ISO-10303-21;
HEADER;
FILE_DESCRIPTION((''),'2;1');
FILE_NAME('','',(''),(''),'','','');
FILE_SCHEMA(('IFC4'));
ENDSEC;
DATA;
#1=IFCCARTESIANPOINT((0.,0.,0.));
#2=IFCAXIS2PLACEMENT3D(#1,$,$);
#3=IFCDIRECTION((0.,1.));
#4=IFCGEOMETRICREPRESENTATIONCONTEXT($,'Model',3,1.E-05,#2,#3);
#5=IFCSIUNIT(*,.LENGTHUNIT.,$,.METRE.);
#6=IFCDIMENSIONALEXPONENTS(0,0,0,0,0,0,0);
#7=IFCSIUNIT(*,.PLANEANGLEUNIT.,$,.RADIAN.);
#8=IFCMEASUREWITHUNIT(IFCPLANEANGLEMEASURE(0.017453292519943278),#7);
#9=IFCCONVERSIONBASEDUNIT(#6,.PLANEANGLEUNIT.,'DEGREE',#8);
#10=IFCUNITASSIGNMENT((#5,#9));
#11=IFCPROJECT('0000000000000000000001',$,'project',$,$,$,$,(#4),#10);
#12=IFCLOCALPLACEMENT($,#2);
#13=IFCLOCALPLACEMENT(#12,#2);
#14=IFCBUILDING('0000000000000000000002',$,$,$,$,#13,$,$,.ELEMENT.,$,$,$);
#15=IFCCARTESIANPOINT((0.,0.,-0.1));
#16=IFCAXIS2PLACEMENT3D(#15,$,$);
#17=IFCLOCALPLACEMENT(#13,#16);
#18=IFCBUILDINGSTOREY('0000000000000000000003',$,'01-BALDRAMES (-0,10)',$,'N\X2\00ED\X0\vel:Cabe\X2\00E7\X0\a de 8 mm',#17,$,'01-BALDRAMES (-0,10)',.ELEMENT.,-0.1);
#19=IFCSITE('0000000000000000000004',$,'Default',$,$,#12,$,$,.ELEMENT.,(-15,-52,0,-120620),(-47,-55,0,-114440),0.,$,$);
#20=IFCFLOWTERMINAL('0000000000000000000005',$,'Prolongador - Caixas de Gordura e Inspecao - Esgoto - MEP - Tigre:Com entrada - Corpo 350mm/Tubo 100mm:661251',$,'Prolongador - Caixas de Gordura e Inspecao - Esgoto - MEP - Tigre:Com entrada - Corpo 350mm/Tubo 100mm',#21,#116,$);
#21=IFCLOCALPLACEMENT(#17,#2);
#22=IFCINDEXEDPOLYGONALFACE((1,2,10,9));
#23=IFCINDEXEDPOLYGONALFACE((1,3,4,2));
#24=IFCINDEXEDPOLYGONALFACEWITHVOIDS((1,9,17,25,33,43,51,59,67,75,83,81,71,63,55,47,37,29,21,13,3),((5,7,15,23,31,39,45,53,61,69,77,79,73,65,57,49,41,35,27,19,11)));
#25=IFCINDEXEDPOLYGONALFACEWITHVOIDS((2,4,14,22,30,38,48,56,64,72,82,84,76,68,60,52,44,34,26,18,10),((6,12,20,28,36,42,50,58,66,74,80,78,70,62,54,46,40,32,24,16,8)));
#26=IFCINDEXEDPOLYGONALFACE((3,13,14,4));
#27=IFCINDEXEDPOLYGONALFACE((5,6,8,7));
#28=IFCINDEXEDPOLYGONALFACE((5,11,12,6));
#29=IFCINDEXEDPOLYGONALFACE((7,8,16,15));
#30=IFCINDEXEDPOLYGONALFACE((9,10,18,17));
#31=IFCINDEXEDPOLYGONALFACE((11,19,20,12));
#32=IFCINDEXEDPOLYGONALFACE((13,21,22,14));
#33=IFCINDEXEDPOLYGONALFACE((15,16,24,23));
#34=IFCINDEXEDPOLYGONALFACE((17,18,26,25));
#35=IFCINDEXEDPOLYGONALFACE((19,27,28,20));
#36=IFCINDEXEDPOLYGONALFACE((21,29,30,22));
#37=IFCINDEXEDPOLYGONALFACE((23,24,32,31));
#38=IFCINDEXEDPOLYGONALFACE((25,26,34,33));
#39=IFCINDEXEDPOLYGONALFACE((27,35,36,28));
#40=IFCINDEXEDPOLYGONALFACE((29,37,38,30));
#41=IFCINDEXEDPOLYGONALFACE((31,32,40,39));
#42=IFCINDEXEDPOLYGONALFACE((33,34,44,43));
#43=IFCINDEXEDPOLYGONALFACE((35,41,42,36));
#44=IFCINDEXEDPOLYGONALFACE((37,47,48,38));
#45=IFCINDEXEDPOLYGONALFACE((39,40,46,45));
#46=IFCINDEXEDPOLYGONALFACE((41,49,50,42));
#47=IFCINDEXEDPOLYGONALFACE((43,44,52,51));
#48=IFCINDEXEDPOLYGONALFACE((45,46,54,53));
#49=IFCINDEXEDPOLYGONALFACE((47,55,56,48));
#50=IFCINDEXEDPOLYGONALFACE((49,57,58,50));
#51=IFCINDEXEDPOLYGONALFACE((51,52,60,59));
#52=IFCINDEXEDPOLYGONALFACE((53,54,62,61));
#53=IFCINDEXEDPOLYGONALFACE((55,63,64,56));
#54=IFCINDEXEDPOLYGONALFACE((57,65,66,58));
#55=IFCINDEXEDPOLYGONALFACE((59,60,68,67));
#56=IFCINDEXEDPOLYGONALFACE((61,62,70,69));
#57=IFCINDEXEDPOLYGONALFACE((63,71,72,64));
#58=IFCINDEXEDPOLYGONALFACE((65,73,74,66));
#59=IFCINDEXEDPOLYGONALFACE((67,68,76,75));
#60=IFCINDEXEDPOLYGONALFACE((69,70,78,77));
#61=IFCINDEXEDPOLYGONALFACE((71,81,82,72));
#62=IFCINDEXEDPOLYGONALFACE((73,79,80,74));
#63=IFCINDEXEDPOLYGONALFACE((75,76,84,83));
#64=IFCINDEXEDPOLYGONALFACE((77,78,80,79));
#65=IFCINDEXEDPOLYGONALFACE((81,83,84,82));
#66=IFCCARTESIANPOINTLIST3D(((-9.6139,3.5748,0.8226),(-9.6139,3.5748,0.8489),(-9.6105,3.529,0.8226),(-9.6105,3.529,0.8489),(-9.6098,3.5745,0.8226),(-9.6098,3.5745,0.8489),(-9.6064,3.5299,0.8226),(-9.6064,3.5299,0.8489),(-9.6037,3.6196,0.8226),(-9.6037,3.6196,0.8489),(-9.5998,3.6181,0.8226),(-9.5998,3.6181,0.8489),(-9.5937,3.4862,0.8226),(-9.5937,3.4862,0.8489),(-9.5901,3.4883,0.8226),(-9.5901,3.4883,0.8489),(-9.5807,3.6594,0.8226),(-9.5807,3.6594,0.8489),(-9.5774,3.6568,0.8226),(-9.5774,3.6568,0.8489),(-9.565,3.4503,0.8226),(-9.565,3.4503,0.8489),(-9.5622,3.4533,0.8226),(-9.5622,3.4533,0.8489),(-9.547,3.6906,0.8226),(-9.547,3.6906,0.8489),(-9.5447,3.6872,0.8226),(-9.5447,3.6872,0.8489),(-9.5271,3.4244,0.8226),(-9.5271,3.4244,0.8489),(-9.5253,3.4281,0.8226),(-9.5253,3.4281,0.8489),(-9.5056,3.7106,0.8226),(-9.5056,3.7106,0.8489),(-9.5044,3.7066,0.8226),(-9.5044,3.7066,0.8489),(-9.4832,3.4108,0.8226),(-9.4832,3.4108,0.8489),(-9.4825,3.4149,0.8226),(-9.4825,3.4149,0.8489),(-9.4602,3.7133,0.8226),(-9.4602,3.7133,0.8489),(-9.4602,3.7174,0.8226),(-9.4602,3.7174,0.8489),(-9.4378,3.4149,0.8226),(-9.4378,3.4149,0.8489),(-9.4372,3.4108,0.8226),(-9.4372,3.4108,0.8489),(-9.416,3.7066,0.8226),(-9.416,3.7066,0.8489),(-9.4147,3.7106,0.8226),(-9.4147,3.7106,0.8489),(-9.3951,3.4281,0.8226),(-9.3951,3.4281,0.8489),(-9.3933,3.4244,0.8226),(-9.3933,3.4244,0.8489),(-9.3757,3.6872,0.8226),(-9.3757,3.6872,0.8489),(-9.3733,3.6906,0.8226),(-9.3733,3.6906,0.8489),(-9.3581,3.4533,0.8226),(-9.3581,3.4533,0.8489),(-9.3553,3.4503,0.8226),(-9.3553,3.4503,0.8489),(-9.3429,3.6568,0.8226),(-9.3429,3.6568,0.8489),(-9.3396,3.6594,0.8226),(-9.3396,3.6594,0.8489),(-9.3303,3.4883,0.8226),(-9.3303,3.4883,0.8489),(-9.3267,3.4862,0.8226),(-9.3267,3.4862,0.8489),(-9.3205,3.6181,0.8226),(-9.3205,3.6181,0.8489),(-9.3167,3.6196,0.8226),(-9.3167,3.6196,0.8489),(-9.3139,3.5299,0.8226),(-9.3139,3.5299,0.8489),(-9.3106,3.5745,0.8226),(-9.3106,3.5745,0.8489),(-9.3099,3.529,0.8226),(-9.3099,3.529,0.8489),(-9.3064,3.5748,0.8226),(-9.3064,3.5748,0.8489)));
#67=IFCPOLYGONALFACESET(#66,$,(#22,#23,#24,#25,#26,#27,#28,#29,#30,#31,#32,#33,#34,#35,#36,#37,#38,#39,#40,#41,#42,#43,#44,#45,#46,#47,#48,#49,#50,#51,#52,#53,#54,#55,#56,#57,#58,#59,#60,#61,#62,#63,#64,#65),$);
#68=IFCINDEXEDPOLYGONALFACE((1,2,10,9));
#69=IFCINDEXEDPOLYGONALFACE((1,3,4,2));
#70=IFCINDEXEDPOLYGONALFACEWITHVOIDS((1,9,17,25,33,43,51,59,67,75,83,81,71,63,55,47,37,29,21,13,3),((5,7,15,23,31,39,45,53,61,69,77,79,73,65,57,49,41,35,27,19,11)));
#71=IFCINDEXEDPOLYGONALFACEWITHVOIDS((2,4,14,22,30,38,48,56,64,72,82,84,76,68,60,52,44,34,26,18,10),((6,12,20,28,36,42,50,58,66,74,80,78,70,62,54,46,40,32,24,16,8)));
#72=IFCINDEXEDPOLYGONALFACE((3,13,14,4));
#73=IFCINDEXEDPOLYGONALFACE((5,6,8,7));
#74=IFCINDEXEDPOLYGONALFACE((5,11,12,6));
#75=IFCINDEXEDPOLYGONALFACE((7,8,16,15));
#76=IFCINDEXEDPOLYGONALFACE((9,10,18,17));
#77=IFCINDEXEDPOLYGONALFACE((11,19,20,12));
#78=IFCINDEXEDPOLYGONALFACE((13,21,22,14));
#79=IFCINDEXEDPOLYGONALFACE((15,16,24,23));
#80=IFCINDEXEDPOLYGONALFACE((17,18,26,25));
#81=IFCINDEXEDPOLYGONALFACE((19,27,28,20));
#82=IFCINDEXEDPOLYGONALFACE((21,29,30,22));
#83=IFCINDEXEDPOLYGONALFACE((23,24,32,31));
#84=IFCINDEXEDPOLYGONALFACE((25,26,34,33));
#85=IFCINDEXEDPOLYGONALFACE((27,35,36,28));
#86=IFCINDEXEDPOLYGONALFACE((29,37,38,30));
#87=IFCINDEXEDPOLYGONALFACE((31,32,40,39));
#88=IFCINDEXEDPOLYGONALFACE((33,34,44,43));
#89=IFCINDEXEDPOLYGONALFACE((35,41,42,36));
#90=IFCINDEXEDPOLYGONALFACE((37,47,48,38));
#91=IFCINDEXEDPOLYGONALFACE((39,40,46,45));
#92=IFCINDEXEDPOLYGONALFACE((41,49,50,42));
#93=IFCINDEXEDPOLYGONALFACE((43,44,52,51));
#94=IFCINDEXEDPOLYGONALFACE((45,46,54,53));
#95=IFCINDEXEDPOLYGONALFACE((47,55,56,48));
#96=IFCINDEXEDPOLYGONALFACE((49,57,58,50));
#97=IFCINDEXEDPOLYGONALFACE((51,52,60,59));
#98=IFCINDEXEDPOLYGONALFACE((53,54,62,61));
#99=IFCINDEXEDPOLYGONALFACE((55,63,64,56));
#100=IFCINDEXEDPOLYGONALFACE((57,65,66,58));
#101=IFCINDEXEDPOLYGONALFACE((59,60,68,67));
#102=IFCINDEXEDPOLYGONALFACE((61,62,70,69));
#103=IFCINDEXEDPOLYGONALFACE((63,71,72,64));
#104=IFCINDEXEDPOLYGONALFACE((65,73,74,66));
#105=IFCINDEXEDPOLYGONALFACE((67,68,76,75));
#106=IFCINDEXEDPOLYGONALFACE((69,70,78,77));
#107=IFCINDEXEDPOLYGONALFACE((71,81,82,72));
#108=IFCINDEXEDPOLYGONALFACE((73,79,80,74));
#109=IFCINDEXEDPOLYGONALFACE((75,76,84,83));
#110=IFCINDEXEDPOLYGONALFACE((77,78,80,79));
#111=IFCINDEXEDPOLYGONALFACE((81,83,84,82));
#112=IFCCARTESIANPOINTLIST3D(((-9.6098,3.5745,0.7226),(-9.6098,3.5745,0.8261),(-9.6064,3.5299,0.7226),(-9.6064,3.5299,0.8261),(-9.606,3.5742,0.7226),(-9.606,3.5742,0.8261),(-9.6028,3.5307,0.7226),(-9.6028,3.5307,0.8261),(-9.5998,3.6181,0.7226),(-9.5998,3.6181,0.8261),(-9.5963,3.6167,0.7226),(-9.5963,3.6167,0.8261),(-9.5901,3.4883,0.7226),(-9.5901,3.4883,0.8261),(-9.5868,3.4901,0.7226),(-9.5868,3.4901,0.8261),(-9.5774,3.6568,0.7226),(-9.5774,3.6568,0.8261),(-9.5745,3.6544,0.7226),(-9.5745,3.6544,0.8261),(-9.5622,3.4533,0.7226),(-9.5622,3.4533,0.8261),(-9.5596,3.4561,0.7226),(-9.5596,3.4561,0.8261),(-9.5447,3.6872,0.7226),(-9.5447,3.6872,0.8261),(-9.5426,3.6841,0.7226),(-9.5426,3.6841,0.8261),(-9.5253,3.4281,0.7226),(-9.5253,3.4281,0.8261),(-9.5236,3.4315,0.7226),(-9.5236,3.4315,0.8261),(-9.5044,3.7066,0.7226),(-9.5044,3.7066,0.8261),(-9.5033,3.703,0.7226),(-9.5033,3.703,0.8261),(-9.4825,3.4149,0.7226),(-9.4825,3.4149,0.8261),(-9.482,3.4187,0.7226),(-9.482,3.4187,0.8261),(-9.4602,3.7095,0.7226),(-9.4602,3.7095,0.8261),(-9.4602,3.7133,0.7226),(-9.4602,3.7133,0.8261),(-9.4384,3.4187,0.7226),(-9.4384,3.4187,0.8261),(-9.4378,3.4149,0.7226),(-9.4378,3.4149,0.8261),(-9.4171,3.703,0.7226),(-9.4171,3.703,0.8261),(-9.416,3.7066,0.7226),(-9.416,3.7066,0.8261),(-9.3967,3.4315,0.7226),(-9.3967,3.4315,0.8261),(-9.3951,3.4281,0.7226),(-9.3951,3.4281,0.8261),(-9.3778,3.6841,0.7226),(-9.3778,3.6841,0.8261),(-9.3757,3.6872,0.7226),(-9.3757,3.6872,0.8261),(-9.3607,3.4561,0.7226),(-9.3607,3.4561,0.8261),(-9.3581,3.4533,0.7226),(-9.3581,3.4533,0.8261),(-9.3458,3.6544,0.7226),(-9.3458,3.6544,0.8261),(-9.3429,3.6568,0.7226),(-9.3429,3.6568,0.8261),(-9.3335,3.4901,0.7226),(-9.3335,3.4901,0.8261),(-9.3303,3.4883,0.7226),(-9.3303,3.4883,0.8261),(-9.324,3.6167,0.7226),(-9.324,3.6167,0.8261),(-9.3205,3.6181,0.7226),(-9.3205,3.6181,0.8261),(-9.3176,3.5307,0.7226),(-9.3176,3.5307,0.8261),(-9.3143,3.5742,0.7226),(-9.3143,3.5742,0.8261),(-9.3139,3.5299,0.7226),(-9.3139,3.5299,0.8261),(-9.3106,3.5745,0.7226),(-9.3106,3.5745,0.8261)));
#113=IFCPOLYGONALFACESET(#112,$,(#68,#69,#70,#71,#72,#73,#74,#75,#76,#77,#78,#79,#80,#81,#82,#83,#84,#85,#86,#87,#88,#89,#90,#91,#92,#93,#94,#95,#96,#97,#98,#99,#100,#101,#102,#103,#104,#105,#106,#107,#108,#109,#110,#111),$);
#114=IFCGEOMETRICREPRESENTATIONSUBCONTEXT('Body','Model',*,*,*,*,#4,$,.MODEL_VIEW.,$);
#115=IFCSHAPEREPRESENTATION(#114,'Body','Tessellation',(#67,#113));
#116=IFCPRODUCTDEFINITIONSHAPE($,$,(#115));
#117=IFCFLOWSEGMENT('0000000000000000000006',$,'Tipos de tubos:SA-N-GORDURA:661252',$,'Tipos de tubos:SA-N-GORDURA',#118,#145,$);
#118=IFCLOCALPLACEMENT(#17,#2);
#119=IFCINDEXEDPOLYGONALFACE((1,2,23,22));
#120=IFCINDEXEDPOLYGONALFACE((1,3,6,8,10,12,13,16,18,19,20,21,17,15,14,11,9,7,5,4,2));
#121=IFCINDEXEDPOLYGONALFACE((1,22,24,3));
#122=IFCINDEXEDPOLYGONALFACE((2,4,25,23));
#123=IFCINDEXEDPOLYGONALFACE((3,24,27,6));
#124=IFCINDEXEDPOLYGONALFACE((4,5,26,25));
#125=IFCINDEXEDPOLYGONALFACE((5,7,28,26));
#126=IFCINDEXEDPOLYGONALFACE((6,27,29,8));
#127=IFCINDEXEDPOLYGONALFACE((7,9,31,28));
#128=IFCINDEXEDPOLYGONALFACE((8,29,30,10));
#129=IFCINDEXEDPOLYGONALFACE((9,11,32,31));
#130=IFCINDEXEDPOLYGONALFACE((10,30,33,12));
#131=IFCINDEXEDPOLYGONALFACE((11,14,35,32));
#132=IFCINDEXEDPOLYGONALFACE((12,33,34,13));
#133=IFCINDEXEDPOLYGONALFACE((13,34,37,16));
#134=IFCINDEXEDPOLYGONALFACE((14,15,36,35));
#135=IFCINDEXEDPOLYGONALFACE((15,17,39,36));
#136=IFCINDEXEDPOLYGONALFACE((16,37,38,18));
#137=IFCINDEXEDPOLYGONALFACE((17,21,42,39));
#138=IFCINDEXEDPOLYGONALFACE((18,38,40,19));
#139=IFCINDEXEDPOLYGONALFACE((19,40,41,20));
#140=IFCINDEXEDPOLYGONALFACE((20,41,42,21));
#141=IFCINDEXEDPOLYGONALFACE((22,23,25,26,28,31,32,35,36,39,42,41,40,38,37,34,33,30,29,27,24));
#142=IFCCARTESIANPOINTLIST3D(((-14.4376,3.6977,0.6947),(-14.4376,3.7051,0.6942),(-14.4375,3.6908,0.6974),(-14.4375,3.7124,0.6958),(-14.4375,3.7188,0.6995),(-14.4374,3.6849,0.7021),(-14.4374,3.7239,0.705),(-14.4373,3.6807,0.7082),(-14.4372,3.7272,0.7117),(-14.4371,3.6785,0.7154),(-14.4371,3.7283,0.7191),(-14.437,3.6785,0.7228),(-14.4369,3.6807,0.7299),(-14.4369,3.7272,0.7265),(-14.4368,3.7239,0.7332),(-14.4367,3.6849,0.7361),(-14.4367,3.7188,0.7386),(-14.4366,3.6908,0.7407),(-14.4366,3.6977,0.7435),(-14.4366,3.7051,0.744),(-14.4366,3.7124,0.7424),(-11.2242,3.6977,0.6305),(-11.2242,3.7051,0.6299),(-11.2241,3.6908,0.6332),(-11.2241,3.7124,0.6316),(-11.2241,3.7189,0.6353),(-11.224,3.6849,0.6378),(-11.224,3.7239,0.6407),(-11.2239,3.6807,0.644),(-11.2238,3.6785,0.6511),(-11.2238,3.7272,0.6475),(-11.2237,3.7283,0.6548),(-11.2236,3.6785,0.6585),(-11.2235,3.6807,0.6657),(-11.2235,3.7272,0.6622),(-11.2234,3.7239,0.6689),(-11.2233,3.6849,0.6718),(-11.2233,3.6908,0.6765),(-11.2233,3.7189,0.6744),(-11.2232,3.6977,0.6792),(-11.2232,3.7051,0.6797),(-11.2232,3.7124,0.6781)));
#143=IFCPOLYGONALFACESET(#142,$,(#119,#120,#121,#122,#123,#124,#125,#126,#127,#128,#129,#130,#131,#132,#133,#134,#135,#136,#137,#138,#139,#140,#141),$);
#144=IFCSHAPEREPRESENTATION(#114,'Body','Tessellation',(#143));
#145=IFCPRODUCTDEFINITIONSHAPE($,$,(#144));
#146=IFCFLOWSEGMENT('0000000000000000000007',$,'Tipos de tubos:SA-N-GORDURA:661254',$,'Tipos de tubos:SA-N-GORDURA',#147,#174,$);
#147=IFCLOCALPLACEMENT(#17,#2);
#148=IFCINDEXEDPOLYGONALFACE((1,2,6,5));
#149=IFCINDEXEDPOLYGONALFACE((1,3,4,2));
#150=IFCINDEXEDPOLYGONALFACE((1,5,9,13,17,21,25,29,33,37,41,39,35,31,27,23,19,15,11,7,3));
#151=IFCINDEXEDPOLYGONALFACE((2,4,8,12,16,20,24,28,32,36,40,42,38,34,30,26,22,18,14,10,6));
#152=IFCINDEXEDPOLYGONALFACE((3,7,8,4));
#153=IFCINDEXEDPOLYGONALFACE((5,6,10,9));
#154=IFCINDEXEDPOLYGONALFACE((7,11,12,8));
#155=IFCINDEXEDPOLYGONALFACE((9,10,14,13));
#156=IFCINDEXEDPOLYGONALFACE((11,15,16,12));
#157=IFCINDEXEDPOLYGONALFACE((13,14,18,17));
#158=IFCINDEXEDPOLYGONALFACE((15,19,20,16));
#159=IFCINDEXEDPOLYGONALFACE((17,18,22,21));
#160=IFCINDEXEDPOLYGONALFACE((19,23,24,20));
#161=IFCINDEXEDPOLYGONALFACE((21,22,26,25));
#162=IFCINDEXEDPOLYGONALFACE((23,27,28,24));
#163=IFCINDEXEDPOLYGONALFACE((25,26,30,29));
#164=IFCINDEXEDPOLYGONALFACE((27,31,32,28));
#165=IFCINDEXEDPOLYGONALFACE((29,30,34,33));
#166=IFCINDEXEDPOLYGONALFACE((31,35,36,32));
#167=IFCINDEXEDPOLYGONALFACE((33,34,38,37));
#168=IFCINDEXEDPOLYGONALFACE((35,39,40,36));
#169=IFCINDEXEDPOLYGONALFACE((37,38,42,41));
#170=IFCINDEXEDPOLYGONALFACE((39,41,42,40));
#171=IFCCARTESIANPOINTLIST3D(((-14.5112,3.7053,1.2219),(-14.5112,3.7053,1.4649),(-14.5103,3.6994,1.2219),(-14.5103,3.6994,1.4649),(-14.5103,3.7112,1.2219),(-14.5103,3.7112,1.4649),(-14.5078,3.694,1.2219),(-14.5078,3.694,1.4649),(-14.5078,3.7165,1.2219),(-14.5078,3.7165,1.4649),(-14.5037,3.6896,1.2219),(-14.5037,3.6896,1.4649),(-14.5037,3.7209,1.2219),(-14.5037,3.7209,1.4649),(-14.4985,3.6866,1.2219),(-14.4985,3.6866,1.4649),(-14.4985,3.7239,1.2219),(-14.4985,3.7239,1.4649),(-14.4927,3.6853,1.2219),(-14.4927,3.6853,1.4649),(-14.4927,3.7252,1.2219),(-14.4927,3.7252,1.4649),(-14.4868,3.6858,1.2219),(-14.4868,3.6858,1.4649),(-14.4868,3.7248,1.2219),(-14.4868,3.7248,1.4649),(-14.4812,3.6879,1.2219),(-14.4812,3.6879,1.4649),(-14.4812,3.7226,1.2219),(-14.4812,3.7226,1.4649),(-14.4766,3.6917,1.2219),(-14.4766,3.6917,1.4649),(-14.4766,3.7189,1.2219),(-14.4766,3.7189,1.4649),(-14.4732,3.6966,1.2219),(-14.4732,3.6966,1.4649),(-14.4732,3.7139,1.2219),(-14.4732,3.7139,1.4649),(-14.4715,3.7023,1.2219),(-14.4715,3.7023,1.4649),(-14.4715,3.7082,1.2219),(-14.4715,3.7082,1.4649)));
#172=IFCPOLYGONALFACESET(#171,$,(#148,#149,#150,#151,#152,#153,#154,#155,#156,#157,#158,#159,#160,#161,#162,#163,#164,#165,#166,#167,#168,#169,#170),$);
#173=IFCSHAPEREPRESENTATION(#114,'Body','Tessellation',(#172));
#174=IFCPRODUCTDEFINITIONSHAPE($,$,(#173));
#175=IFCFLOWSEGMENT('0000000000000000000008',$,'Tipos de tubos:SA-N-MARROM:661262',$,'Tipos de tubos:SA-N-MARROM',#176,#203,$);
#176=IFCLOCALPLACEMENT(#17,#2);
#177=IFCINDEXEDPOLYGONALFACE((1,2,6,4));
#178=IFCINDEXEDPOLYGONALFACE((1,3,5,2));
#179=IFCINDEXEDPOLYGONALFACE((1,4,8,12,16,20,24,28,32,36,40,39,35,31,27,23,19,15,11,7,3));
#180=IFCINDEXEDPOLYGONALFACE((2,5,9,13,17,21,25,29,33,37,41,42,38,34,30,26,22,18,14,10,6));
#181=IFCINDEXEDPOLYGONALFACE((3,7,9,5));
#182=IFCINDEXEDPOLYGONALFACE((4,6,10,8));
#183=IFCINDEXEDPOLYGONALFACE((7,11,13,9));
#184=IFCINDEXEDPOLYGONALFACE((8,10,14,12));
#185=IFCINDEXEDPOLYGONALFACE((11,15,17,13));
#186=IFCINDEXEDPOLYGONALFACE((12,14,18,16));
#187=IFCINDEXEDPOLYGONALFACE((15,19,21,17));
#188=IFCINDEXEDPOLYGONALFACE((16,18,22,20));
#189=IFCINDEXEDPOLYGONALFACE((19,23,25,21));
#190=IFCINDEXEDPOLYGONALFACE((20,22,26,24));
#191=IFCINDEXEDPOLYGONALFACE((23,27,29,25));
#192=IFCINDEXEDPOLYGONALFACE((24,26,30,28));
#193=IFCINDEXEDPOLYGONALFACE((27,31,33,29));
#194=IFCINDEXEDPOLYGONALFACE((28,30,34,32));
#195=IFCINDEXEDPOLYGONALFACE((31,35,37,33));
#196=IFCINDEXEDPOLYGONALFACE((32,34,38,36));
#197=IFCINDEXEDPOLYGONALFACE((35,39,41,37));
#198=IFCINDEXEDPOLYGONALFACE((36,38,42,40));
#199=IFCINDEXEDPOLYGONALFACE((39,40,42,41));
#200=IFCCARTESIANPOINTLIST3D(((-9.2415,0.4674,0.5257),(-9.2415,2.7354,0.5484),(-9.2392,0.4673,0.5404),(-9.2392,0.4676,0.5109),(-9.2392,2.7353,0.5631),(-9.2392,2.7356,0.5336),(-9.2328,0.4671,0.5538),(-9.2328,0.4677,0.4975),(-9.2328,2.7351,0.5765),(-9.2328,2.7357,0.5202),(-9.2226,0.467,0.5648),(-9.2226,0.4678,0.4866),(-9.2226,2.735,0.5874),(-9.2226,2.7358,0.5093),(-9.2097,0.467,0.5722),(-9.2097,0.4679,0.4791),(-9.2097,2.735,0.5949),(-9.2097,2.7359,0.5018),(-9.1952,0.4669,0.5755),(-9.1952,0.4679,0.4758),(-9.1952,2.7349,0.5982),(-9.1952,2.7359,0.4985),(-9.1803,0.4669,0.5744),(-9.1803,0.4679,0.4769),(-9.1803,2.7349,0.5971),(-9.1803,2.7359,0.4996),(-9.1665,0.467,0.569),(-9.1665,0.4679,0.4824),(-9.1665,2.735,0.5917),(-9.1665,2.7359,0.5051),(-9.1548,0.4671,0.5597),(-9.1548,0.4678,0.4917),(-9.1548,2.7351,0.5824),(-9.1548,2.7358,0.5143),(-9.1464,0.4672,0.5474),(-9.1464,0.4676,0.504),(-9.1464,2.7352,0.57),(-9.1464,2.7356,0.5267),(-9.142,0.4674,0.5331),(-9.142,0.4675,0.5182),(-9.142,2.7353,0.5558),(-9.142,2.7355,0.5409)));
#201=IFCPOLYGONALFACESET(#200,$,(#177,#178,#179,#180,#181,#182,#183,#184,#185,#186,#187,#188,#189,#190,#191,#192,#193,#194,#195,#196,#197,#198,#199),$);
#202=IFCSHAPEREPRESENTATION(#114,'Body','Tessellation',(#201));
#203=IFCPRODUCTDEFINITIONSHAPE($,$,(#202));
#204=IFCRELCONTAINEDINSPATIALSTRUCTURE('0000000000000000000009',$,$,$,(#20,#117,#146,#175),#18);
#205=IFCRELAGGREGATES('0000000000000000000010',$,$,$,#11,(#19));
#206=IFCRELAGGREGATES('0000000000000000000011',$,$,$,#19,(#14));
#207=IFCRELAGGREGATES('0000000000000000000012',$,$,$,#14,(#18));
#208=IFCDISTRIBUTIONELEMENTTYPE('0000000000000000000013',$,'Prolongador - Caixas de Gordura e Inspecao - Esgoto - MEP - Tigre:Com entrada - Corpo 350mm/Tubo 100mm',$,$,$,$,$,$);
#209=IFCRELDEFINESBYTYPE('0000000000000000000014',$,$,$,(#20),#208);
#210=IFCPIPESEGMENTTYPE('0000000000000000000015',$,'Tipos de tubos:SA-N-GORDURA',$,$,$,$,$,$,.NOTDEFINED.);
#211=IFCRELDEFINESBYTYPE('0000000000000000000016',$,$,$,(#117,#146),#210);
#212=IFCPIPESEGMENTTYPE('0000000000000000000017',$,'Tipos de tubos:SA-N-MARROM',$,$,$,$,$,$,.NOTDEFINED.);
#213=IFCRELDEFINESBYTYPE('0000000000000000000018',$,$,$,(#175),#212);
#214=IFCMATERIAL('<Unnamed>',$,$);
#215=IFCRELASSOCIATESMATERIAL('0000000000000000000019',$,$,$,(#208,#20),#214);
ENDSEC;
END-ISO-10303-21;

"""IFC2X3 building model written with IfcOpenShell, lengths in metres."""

from ifc_helpers import new_model, entity, si_unit, converted_unit, direction, frame, frame_2d, origin, origin_2d_with_axis, place, context, subcontext, project, spatial, circle, hollow_circle, extrude, source, transform, mapped, material, type_object, type_shapes, element, save


model = new_model("IFC2X3")

# Units and contexts
model_context = context("Model", 3, precision=1e-05, world=origin(), true_north=direction((0.0, 1.0)))
body_context = subcontext(model_context, "Body", "Model", "MODEL_VIEW")
ifc_project = project(units=[si_unit("LENGTHUNIT", "METRE"), converted_unit("PLANEANGLEUNIT", "DEGREE", entity("IfcPlaneAngleMeasure", 0.017453292519943278), si_unit("PLANEANGLEUNIT", "RADIAN"), dimensions=[0, 0, 0, 0, 0, 0, 0])], contexts=[model_context])

# Site, building, storey
site_placement = place(None, origin())
site = spatial("IfcSite", under=ifc_project, at=site_placement, Name="Default", CompositionType="ELEMENT", RefLatitude=(-15, -52, 0, -120620), RefLongitude=(-47, -55, 0, -114440), RefElevation=0.0)
building_placement = place(site_placement, origin())
building = spatial("IfcBuilding", under=site, at=building_placement, CompositionType="ELEMENT")
storey_placement = place(building_placement, frame((0.0, 0.0, -0.1)))
storey = spatial("IfcBuildingStorey", under=building, at=storey_placement, Name="01-BALDRAMES (-0,10)", ObjectType="Nível:Cabeça de 8 mm", LongName="01-BALDRAMES (-0,10)", CompositionType="ELEMENT", Elevation=-0.1)

# Flow terminal
ifc_material = material(Name="<Unnamed>")
distribution_element_type_1 = type_object("IfcDistributionElementType", Name="Prolongador - Caixas de Gordura e Inspecao - Esgoto - MEP - Tigre:Com entrada - Corpo 350mm/Tubo 100mm", material=ifc_material)
shared_shape_1 = source(origin(), body_context, "Body", "SweptSolid", [
    extrude(hollow_circle(Radius=0.1542, WallThickness=0.0042, at=frame_2d((0.0, 0.0), x_axis=(1.0, 0.0))), frame((0.0, 0.0, -0.0574), z_axis=(0.0, 0.0, 1.0), x_axis=(0.0, -1.0, 0.0)), (0.0, 0.0, 1.0), 0.0263),
    extrude(hollow_circle(Radius=0.15, WallThickness=0.0038, at=frame_2d((0.0, 0.0), x_axis=(1.0, 0.0))), frame((0.0, 0.0, -0.1574), z_axis=(0.0, 0.0, 1.0), x_axis=(0.0, -1.0, 0.0)), (0.0, 0.0, 1.0), 0.1035),
])
type_shapes(distribution_element_type_1, [shared_shape_1])
flow_terminal_1_placement = place(storey_placement, frame((-9.4602, 3.5633, 0.88), z_axis=(0.0, 0.0, 1.0), x_axis=(-1.0, -0.000001, 0.0)))
element("IfcFlowTerminal", 1, at=flow_terminal_1_placement, inside=storey, type_object=distribution_element_type_1, material=ifc_material, Name="Prolongador - Caixas de Gordura e Inspecao - Esgoto - MEP - Tigre:Com entrada - Corpo 350mm/Tubo 100mm:661251", ObjectType="Prolongador - Caixas de Gordura e Inspecao - Esgoto - MEP - Tigre:Com entrada - Corpo 350mm/Tubo 100mm", context=body_context, shape_type="MappedRepresentation", body=[
    mapped(shared_shape_1, transform((0.0, 0.0, 0.0), scale=1.0)),
])

# Flow segments
pipe_segment_type_1 = type_object("IfcPipeSegmentType", Name="Tipos de tubos:SA-N-GORDURA", PredefinedType="NOTDEFINED")
flow_segment_1_placement = place(storey_placement, origin())
element("IfcFlowSegment", 2, at=flow_segment_1_placement, inside=storey, type_object=pipe_segment_type_1, Name="Tipos de tubos:SA-N-GORDURA:661252", ObjectType="Tipos de tubos:SA-N-GORDURA", context=body_context, shape_type="SweptSolid", body=[
    extrude(circle(Radius=0.025, at=origin_2d_with_axis()), frame((-11.2237, 3.7033, 0.6548), z_axis=(-0.9998, -0.000001, 0.019996), x_axis=(-0.000001, 1.0, 0.0)), (0.0, 0.0, 1.0), 3.214),
])
flow_segment_2_placement = place(storey_placement, origin())
element("IfcFlowSegment", 3, at=flow_segment_2_placement, inside=storey, type_object=pipe_segment_type_1, Name="Tipos de tubos:SA-N-GORDURA:661254", ObjectType="Tipos de tubos:SA-N-GORDURA", context=body_context, shape_type="SweptSolid", body=[
    extrude(circle(Radius=0.02, at=origin_2d_with_axis()), frame((-14.4912, 3.7053, 1.2219), z_axis=(0.0, 0.0, 1.0), x_axis=(-1.0, 0.0, 0.0)), (0.0, 0.0, 1.0), 0.243),
])
pipe_segment_type_2 = type_object("IfcPipeSegmentType", Name="Tipos de tubos:SA-N-MARROM", PredefinedType="NOTDEFINED")
flow_segment_3_placement = place(storey_placement, origin())
element("IfcFlowSegment", 4, at=flow_segment_3_placement, inside=storey, type_object=pipe_segment_type_2, Name="Tipos de tubos:SA-N-MARROM:661262", ObjectType="Tipos de tubos:SA-N-MARROM", context=body_context, shape_type="SweptSolid", body=[
    extrude(circle(Radius=0.05, at=frame_2d((0.0, 0.0), x_axis=(1.0, 0.0))), frame((-9.1915, 0.4674, 0.5257), z_axis=(-0.000001, 0.99995, 0.01), x_axis=(-1.0, -0.000001, 0.0)), (0.0, 0.0, 1.0), 2.2681),
])

save(model, "model.ifc")
